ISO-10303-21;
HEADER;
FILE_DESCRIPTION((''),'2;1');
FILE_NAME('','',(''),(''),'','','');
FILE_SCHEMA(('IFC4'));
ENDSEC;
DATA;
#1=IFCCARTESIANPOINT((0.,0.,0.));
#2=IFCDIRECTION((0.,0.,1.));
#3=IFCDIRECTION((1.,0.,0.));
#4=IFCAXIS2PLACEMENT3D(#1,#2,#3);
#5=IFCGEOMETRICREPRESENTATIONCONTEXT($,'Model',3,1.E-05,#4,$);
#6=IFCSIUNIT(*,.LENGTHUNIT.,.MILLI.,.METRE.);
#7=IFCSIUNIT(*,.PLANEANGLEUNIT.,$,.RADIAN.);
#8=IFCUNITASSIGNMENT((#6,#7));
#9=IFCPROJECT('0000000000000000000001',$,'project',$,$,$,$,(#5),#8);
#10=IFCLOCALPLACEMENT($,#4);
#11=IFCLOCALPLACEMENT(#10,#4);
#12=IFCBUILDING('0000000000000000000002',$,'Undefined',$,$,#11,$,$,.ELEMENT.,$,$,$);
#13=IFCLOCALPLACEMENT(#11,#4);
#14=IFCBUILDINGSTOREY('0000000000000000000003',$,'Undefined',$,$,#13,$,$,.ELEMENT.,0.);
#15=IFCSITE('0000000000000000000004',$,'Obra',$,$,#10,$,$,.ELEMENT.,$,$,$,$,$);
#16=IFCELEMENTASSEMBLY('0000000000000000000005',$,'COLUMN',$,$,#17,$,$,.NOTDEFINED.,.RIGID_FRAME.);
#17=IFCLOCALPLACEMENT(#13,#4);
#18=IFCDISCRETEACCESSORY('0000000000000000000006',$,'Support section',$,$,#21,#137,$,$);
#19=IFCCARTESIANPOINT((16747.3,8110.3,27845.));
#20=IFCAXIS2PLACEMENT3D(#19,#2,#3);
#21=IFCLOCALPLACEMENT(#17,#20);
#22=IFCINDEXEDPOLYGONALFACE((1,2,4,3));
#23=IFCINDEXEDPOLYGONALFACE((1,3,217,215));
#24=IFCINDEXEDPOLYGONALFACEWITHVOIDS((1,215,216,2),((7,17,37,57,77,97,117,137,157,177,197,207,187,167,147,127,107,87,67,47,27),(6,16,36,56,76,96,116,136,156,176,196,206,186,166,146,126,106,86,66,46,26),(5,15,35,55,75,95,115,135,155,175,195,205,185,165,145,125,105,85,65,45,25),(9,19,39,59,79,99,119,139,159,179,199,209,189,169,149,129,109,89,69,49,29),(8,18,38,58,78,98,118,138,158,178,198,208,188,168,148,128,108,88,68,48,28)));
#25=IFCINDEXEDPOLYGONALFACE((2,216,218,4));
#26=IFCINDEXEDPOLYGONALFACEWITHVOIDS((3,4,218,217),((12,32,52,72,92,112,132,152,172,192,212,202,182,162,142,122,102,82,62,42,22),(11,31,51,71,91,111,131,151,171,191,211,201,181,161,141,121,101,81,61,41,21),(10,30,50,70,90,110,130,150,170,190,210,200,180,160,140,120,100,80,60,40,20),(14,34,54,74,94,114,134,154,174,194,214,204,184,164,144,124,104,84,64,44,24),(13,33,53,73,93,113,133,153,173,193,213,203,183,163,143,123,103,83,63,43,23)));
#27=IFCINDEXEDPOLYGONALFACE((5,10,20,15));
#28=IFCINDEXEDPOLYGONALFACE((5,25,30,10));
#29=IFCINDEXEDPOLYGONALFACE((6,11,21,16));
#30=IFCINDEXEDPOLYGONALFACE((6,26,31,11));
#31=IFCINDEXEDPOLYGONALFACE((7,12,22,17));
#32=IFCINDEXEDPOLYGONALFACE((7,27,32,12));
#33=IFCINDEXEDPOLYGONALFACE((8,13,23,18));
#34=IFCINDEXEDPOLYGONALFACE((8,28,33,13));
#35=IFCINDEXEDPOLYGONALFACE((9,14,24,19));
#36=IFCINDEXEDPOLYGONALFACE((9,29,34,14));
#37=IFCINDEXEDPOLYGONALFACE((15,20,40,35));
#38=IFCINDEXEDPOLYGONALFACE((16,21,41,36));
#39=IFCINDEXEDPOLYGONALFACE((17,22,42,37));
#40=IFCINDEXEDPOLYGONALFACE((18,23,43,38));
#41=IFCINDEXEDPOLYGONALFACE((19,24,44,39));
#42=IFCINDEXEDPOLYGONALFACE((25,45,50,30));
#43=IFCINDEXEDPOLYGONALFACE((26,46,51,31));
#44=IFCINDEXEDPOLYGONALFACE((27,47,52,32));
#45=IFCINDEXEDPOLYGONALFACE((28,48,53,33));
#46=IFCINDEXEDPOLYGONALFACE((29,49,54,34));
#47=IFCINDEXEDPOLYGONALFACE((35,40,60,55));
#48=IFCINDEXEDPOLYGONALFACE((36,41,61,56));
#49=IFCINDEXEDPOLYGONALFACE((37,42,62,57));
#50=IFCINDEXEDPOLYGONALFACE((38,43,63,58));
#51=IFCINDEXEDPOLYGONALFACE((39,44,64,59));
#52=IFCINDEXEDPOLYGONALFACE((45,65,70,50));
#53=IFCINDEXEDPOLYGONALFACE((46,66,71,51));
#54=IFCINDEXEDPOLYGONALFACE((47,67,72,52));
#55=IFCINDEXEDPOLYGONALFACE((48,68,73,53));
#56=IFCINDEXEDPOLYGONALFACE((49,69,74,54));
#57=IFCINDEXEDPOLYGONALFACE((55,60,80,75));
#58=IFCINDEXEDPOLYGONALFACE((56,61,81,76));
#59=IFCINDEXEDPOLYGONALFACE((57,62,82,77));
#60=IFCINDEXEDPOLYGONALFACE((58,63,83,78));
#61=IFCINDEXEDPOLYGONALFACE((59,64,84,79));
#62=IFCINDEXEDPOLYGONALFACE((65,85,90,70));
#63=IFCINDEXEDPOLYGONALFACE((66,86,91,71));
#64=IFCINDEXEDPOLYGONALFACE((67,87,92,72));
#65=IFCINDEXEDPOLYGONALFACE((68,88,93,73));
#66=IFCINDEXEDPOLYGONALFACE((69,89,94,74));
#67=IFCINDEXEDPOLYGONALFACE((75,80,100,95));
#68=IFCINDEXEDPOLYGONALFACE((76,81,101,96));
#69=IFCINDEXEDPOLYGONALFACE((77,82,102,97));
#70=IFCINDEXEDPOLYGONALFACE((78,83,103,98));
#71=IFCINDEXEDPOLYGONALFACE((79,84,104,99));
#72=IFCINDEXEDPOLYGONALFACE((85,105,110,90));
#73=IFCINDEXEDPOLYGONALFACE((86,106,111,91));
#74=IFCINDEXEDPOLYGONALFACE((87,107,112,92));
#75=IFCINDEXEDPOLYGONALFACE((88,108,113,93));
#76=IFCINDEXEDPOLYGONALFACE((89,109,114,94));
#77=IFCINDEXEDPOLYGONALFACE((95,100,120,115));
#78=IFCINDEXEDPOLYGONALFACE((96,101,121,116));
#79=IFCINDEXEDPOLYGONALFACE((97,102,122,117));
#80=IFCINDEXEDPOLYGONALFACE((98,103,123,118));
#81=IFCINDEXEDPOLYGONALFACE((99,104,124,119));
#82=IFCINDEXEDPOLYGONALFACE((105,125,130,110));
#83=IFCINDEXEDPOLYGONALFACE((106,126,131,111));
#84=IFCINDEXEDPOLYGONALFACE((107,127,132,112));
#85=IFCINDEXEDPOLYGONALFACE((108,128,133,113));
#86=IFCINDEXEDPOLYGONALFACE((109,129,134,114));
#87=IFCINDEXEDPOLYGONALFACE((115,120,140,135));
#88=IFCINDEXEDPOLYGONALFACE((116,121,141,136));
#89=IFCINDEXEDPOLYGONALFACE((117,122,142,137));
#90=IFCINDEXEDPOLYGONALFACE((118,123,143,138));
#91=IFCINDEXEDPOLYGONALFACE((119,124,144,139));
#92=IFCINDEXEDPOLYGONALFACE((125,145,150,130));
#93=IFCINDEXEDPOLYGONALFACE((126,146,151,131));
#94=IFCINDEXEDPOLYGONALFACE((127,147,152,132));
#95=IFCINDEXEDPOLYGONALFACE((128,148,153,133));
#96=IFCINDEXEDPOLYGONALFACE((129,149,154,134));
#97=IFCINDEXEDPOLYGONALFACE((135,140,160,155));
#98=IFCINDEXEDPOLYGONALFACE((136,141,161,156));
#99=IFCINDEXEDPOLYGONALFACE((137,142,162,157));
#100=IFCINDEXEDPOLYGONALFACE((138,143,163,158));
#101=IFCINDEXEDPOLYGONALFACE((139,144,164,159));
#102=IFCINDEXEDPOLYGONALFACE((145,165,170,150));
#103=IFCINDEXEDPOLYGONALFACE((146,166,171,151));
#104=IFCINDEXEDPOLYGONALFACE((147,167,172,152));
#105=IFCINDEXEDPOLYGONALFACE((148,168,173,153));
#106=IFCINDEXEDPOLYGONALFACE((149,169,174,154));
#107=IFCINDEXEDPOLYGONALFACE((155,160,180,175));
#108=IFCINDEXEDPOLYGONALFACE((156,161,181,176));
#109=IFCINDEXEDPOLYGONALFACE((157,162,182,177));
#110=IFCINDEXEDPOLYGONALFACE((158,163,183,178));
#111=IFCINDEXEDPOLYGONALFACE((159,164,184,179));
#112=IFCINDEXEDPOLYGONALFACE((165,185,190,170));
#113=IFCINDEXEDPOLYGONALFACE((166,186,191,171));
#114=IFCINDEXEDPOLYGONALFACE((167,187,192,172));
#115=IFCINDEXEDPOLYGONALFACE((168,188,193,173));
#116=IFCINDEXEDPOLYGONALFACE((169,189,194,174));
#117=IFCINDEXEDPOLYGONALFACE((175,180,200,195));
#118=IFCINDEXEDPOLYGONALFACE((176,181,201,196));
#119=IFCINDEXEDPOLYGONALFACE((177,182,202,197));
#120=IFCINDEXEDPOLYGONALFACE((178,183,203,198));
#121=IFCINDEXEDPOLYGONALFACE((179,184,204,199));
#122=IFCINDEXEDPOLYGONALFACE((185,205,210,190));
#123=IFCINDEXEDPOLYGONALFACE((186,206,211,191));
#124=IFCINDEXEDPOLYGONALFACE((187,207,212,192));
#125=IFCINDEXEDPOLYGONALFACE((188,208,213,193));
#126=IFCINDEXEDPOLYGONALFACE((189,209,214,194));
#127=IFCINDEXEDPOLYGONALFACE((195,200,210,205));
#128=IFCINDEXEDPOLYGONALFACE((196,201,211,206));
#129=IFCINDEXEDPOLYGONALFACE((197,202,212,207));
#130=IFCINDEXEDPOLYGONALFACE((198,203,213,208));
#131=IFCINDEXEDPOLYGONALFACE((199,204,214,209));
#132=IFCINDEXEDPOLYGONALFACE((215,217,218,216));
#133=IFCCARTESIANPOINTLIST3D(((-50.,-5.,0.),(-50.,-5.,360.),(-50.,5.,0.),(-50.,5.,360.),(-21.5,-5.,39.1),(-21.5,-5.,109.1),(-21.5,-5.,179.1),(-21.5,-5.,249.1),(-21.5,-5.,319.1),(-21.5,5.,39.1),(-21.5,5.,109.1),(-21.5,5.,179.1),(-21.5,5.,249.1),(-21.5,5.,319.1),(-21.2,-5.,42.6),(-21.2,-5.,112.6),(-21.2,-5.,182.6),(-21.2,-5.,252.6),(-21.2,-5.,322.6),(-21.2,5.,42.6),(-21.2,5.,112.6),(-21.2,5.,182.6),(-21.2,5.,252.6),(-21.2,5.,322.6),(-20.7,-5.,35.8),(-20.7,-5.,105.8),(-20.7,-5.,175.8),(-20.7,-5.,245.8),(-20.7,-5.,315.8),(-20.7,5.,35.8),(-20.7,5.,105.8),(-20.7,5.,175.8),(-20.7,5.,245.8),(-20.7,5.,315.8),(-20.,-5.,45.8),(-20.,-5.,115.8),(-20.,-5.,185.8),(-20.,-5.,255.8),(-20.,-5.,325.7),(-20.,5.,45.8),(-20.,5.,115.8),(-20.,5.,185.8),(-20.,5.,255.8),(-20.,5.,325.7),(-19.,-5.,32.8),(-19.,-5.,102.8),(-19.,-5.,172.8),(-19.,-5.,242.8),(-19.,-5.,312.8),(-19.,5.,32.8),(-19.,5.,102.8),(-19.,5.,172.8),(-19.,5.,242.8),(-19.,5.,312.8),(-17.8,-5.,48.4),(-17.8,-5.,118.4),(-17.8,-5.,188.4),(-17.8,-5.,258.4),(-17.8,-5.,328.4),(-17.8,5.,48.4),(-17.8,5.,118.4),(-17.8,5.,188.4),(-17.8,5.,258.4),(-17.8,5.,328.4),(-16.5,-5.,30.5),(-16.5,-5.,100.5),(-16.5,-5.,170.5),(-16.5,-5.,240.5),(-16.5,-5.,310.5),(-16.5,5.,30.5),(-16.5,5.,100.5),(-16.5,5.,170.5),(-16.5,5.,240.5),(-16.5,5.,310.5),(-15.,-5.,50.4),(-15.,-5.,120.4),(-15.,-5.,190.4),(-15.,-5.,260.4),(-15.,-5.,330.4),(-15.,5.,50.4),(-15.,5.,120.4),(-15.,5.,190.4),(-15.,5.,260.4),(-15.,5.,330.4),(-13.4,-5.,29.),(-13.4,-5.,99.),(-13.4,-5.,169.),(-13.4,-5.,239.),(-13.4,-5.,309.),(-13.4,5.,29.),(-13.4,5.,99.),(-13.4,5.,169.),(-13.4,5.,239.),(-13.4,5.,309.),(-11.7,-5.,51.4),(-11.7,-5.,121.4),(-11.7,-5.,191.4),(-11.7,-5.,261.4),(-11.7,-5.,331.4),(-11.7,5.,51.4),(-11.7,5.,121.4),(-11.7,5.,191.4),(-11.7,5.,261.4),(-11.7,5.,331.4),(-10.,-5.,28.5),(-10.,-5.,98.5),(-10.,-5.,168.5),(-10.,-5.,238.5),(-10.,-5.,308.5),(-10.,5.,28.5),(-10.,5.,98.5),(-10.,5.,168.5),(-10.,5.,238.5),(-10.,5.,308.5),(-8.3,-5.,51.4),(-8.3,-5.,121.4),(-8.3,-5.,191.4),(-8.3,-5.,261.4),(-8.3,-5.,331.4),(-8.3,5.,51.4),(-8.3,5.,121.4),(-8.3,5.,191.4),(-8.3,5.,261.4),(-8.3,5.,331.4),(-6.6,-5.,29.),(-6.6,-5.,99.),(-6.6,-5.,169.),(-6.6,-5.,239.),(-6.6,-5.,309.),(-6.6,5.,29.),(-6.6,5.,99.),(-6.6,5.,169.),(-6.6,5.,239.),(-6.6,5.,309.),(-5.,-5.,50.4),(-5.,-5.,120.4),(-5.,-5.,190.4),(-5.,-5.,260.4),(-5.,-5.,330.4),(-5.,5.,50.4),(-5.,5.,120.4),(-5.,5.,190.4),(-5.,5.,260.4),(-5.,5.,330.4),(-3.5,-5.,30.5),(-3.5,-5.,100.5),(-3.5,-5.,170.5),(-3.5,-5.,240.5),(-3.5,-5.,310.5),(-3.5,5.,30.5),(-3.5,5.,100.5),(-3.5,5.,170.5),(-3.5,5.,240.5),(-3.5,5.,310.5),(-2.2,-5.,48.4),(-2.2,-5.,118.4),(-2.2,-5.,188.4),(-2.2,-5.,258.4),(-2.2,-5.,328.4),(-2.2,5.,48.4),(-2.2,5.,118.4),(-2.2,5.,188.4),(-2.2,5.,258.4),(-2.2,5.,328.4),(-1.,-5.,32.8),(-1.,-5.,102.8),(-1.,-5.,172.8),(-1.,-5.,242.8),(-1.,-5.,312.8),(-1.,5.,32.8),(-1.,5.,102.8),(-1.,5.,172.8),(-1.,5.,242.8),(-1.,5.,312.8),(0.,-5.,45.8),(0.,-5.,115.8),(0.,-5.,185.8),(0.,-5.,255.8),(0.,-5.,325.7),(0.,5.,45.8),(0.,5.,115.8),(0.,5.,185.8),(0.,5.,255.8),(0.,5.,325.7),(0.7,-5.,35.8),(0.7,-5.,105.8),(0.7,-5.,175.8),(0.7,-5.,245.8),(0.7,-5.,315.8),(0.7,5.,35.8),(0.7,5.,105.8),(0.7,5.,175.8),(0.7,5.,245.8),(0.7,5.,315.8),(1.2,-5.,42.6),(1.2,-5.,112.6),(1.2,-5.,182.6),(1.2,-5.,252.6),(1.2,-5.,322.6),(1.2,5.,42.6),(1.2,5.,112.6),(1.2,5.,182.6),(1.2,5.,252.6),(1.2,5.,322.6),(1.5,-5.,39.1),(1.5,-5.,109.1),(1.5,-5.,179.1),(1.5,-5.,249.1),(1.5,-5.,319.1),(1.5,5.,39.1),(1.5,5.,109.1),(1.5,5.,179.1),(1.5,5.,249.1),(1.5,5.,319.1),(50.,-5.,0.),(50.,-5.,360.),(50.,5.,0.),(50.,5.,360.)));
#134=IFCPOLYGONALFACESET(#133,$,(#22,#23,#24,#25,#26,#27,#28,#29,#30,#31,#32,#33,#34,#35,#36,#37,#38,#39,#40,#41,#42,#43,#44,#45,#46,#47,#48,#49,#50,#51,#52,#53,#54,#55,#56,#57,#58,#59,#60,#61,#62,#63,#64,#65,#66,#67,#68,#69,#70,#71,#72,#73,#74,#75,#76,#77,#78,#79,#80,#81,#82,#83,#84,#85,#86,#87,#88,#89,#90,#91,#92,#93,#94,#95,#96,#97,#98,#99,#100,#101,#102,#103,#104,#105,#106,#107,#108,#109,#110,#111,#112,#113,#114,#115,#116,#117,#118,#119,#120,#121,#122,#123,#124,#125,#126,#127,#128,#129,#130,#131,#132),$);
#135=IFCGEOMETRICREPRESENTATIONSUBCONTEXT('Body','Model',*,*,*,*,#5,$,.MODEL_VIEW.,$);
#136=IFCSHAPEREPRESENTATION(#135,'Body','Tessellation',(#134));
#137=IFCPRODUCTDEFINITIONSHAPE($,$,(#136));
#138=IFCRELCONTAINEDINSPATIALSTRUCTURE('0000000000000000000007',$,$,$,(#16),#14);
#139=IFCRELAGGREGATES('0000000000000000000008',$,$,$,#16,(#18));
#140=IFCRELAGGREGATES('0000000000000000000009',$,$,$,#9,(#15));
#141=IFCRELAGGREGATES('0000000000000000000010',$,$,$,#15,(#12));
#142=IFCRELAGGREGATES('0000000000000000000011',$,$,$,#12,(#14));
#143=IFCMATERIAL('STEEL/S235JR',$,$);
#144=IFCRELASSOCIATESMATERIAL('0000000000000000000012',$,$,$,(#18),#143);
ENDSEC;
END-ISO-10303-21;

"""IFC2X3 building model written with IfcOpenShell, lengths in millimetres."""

from ifc_helpers import new_model, si_unit, frame, origin_with_axes, origin_2d_with_axis, place, context, subcontext, project, spatial, rectangle, circle, extrude, source, transform, mapped, material, element, aggregate, save


model = new_model("IFC2X3")

# Units and contexts
model_context = context("Model", 3, precision=1e-05, world=origin_with_axes())
body_context = subcontext(model_context, "Body", "Model", "MODEL_VIEW")
ifc_project = project(units=[si_unit("LENGTHUNIT", "METRE", prefix="MILLI"), si_unit("PLANEANGLEUNIT", "RADIAN")], contexts=[model_context])

# Site, building, storey
site_placement = place(None, origin_with_axes())
site = spatial("IfcSite", under=ifc_project, at=site_placement, Name="Obra", CompositionType="ELEMENT")
building_placement = place(site_placement, origin_with_axes())
building = spatial("IfcBuilding", under=site, at=building_placement, Name="Undefined", CompositionType="ELEMENT")
storey_placement = place(building_placement, origin_with_axes())
storey = spatial("IfcBuildingStorey", under=building, at=storey_placement, Name="Undefined", CompositionType="ELEMENT", Elevation=0.0)

# Element assembly
assembly_1_placement = place(storey_placement, origin_with_axes())
assembly_1 = element("IfcElementAssembly", 1, at=assembly_1_placement, inside=storey, Name="COLUMN", AssemblyPlace="NOTDEFINED", PredefinedType="RIGID_FRAME")
ifc_material_1 = material(Name="STEEL/S235JR")

# Discrete accessory, opening
discrete_accessory_1_placement = place(assembly_1_placement, frame((16747.3, 8110.3, 27845.0), z_axis=(0.0, 0.0, 1.0), x_axis=(1.0, 0.0, 0.0)))
discrete_accessory_1 = element("IfcDiscreteAccessory", 2, at=discrete_accessory_1_placement, material=ifc_material_1, Name="Support section", context=body_context, shape_type="SweptSolid", body=[
    extrude(rectangle(XDim=10.0, YDim=100.0, at=origin_2d_with_axis()), frame((0.0, 0.0, 360.0), z_axis=(0.0, 0.0, -1.0), x_axis=(0.0, 1.0, 0.0)), (0.0, 0.0, 1.0), 360.0),
])
shared_shape_1 = source(origin_with_axes(), body_context, "Body", "SweptSolid", [
    extrude(circle(Radius=11.5, at=origin_2d_with_axis()), frame((0.0, 4.6, 0.0), z_axis=(0.0, 1.0, 0.0), x_axis=(1.0, 0.0, 0.0)), (0.0, 0.0, 1.0), 10.2),
])
opening_1_placement = place(assembly_1_placement, frame((16777.3, 8120.0, 28250.0), z_axis=(-1.0, 0.0, 0.0), x_axis=(0.0, 0.0, -1.0)))
element("IfcOpeningElement", 3, at=opening_1_placement, cuts=discrete_accessory_1, ObjectType="Opening", context=body_context, shape_type="MappedRepresentation", body=[
    mapped(shared_shape_1, transform((85.0, 0.0, 40.0))),
    mapped(shared_shape_1, transform((155.0, 0.0, 40.0))),
    mapped(shared_shape_1, transform((225.0, 0.0, 40.0))),
    mapped(shared_shape_1, transform((295.0, 0.0, 40.0))),
    mapped(shared_shape_1, transform((365.0, 0.0, 40.0))),
])
aggregate(assembly_1, [discrete_accessory_1])

save(model, "model.ifc")
